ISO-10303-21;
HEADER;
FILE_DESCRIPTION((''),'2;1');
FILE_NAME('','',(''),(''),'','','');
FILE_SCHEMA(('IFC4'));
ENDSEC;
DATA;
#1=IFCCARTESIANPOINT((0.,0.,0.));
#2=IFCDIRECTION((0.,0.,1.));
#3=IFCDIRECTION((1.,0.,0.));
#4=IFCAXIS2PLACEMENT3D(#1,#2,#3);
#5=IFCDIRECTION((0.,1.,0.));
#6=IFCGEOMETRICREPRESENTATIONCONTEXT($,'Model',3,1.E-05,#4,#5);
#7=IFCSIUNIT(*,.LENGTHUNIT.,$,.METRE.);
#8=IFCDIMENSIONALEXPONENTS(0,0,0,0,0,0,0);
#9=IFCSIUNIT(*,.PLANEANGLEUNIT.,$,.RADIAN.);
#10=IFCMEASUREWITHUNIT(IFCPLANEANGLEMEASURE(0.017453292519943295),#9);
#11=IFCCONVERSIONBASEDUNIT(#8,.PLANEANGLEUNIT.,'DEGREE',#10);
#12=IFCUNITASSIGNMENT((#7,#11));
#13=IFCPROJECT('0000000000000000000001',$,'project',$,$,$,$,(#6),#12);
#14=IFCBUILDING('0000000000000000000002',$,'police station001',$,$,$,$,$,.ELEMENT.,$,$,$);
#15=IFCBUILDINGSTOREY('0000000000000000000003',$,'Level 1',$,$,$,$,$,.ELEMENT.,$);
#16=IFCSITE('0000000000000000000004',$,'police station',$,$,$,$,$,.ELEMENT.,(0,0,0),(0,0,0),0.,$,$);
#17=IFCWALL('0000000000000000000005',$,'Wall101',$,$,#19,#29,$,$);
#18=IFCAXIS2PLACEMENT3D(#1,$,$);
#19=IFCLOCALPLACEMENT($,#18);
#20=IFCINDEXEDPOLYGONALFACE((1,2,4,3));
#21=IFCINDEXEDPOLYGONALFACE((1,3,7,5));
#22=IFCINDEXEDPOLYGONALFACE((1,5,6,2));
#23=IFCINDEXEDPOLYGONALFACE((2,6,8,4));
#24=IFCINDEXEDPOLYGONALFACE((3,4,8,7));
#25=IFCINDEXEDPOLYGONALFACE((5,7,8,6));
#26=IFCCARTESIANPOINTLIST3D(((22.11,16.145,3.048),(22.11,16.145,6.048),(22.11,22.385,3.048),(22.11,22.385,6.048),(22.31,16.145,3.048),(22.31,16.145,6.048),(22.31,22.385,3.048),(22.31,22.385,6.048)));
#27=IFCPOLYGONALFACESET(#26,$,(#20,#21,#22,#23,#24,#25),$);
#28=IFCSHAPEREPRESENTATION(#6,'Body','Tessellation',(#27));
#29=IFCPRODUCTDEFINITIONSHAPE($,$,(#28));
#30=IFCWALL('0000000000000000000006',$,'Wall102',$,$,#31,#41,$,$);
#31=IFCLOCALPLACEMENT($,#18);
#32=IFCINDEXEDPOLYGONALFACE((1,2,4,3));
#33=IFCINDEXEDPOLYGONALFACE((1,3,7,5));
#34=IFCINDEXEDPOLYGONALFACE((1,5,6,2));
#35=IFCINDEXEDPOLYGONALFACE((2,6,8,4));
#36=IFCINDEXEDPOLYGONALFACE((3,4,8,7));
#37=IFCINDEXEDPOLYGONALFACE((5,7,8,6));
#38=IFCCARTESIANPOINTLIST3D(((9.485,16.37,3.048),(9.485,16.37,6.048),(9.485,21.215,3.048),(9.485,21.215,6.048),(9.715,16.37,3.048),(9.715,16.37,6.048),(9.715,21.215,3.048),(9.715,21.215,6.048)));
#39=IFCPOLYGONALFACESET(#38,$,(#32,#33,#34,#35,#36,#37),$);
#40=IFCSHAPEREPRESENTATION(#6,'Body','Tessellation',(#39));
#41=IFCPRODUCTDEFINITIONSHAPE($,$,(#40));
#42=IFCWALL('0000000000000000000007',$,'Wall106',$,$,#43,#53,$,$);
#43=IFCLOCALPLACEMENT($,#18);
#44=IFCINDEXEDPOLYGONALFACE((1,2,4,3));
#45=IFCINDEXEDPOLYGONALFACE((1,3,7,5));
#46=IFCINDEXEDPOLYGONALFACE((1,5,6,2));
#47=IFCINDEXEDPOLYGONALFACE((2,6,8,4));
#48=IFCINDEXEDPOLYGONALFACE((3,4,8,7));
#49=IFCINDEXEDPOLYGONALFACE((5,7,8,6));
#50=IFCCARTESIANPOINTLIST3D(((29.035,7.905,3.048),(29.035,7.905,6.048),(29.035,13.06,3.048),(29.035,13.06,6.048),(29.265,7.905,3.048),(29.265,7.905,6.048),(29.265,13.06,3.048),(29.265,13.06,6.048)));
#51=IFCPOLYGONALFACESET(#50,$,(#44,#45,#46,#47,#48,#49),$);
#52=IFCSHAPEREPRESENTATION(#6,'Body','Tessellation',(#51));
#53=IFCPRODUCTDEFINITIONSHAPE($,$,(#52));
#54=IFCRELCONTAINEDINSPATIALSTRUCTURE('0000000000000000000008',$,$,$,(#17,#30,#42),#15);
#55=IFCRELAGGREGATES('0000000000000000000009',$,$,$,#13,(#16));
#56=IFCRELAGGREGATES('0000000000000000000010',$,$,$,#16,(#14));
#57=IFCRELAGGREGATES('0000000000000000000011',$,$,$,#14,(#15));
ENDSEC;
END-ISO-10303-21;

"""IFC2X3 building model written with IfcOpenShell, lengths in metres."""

from ifc_helpers import new_model, entity, si_unit, converted_unit, direction, frame, frame_2d, origin_with_axes, place, context, project, spatial, rectangle, extrude, element, save


model = new_model("IFC2X3")

# Units and contexts
model_context = context("Model", 3, precision=1e-05, world=origin_with_axes(), true_north=direction((0.0, 1.0, 0.0)))
ifc_project = project(units=[si_unit("LENGTHUNIT", "METRE"), converted_unit("PLANEANGLEUNIT", "DEGREE", entity("IfcPlaneAngleMeasure", 0.017453292519943295), si_unit("PLANEANGLEUNIT", "RADIAN"), dimensions=[0, 0, 0, 0, 0, 0, 0])], contexts=[model_context])

# Site, building, storey
site = spatial("IfcSite", under=ifc_project, Name="police station", CompositionType="ELEMENT", RefLatitude=(0, 0, 0), RefLongitude=(0, 0, 0), RefElevation=0.0)
building = spatial("IfcBuilding", under=site, Name="police station001", CompositionType="ELEMENT")
storey = spatial("IfcBuildingStorey", under=building, Name="Level 1", CompositionType="ELEMENT")

# Shared definitions
placement = place(None, origin_with_axes())

# Walls
element("IfcWall", 1, at=placement, inside=storey, Name="Wall101", context=model_context, shape_type="SweptSolid", body=[
    extrude(rectangle(XDim=6.24, YDim=0.2, at=frame_2d((0.0, 0.0), x_axis=(0.0, -1.0, 0.0))), frame((22.21, 19.265, 3.048), z_axis=(0.0, 0.0, 1.0), x_axis=(1.0, 0.0, 0.0)), (0.0, 0.0, 1.0), 3.0),
])
element("IfcWall", 2, at=placement, inside=storey, Name="Wall102", context=model_context, shape_type="SweptSolid", body=[
    extrude(rectangle(XDim=4.845, YDim=0.23, at=frame_2d((0.0, 0.0), x_axis=(0.0, -1.0, 0.0))), frame((9.6, 18.7925, 3.048), z_axis=(0.0, 0.0, 1.0), x_axis=(1.0, 0.0, 0.0)), (0.0, 0.0, 1.0), 3.0),
])
element("IfcWall", 3, at=placement, inside=storey, Name="Wall106", context=model_context, shape_type="SweptSolid", body=[
    extrude(rectangle(XDim=5.155, YDim=0.23, at=frame_2d((0.0, 0.0), x_axis=(0.0, -1.0, 0.0))), frame((29.15, 10.4825, 3.048), z_axis=(0.0, 0.0, 1.0), x_axis=(1.0, 0.0, 0.0)), (0.0, 0.0, 1.0), 3.0),
])

save(model, "model.ifc")
